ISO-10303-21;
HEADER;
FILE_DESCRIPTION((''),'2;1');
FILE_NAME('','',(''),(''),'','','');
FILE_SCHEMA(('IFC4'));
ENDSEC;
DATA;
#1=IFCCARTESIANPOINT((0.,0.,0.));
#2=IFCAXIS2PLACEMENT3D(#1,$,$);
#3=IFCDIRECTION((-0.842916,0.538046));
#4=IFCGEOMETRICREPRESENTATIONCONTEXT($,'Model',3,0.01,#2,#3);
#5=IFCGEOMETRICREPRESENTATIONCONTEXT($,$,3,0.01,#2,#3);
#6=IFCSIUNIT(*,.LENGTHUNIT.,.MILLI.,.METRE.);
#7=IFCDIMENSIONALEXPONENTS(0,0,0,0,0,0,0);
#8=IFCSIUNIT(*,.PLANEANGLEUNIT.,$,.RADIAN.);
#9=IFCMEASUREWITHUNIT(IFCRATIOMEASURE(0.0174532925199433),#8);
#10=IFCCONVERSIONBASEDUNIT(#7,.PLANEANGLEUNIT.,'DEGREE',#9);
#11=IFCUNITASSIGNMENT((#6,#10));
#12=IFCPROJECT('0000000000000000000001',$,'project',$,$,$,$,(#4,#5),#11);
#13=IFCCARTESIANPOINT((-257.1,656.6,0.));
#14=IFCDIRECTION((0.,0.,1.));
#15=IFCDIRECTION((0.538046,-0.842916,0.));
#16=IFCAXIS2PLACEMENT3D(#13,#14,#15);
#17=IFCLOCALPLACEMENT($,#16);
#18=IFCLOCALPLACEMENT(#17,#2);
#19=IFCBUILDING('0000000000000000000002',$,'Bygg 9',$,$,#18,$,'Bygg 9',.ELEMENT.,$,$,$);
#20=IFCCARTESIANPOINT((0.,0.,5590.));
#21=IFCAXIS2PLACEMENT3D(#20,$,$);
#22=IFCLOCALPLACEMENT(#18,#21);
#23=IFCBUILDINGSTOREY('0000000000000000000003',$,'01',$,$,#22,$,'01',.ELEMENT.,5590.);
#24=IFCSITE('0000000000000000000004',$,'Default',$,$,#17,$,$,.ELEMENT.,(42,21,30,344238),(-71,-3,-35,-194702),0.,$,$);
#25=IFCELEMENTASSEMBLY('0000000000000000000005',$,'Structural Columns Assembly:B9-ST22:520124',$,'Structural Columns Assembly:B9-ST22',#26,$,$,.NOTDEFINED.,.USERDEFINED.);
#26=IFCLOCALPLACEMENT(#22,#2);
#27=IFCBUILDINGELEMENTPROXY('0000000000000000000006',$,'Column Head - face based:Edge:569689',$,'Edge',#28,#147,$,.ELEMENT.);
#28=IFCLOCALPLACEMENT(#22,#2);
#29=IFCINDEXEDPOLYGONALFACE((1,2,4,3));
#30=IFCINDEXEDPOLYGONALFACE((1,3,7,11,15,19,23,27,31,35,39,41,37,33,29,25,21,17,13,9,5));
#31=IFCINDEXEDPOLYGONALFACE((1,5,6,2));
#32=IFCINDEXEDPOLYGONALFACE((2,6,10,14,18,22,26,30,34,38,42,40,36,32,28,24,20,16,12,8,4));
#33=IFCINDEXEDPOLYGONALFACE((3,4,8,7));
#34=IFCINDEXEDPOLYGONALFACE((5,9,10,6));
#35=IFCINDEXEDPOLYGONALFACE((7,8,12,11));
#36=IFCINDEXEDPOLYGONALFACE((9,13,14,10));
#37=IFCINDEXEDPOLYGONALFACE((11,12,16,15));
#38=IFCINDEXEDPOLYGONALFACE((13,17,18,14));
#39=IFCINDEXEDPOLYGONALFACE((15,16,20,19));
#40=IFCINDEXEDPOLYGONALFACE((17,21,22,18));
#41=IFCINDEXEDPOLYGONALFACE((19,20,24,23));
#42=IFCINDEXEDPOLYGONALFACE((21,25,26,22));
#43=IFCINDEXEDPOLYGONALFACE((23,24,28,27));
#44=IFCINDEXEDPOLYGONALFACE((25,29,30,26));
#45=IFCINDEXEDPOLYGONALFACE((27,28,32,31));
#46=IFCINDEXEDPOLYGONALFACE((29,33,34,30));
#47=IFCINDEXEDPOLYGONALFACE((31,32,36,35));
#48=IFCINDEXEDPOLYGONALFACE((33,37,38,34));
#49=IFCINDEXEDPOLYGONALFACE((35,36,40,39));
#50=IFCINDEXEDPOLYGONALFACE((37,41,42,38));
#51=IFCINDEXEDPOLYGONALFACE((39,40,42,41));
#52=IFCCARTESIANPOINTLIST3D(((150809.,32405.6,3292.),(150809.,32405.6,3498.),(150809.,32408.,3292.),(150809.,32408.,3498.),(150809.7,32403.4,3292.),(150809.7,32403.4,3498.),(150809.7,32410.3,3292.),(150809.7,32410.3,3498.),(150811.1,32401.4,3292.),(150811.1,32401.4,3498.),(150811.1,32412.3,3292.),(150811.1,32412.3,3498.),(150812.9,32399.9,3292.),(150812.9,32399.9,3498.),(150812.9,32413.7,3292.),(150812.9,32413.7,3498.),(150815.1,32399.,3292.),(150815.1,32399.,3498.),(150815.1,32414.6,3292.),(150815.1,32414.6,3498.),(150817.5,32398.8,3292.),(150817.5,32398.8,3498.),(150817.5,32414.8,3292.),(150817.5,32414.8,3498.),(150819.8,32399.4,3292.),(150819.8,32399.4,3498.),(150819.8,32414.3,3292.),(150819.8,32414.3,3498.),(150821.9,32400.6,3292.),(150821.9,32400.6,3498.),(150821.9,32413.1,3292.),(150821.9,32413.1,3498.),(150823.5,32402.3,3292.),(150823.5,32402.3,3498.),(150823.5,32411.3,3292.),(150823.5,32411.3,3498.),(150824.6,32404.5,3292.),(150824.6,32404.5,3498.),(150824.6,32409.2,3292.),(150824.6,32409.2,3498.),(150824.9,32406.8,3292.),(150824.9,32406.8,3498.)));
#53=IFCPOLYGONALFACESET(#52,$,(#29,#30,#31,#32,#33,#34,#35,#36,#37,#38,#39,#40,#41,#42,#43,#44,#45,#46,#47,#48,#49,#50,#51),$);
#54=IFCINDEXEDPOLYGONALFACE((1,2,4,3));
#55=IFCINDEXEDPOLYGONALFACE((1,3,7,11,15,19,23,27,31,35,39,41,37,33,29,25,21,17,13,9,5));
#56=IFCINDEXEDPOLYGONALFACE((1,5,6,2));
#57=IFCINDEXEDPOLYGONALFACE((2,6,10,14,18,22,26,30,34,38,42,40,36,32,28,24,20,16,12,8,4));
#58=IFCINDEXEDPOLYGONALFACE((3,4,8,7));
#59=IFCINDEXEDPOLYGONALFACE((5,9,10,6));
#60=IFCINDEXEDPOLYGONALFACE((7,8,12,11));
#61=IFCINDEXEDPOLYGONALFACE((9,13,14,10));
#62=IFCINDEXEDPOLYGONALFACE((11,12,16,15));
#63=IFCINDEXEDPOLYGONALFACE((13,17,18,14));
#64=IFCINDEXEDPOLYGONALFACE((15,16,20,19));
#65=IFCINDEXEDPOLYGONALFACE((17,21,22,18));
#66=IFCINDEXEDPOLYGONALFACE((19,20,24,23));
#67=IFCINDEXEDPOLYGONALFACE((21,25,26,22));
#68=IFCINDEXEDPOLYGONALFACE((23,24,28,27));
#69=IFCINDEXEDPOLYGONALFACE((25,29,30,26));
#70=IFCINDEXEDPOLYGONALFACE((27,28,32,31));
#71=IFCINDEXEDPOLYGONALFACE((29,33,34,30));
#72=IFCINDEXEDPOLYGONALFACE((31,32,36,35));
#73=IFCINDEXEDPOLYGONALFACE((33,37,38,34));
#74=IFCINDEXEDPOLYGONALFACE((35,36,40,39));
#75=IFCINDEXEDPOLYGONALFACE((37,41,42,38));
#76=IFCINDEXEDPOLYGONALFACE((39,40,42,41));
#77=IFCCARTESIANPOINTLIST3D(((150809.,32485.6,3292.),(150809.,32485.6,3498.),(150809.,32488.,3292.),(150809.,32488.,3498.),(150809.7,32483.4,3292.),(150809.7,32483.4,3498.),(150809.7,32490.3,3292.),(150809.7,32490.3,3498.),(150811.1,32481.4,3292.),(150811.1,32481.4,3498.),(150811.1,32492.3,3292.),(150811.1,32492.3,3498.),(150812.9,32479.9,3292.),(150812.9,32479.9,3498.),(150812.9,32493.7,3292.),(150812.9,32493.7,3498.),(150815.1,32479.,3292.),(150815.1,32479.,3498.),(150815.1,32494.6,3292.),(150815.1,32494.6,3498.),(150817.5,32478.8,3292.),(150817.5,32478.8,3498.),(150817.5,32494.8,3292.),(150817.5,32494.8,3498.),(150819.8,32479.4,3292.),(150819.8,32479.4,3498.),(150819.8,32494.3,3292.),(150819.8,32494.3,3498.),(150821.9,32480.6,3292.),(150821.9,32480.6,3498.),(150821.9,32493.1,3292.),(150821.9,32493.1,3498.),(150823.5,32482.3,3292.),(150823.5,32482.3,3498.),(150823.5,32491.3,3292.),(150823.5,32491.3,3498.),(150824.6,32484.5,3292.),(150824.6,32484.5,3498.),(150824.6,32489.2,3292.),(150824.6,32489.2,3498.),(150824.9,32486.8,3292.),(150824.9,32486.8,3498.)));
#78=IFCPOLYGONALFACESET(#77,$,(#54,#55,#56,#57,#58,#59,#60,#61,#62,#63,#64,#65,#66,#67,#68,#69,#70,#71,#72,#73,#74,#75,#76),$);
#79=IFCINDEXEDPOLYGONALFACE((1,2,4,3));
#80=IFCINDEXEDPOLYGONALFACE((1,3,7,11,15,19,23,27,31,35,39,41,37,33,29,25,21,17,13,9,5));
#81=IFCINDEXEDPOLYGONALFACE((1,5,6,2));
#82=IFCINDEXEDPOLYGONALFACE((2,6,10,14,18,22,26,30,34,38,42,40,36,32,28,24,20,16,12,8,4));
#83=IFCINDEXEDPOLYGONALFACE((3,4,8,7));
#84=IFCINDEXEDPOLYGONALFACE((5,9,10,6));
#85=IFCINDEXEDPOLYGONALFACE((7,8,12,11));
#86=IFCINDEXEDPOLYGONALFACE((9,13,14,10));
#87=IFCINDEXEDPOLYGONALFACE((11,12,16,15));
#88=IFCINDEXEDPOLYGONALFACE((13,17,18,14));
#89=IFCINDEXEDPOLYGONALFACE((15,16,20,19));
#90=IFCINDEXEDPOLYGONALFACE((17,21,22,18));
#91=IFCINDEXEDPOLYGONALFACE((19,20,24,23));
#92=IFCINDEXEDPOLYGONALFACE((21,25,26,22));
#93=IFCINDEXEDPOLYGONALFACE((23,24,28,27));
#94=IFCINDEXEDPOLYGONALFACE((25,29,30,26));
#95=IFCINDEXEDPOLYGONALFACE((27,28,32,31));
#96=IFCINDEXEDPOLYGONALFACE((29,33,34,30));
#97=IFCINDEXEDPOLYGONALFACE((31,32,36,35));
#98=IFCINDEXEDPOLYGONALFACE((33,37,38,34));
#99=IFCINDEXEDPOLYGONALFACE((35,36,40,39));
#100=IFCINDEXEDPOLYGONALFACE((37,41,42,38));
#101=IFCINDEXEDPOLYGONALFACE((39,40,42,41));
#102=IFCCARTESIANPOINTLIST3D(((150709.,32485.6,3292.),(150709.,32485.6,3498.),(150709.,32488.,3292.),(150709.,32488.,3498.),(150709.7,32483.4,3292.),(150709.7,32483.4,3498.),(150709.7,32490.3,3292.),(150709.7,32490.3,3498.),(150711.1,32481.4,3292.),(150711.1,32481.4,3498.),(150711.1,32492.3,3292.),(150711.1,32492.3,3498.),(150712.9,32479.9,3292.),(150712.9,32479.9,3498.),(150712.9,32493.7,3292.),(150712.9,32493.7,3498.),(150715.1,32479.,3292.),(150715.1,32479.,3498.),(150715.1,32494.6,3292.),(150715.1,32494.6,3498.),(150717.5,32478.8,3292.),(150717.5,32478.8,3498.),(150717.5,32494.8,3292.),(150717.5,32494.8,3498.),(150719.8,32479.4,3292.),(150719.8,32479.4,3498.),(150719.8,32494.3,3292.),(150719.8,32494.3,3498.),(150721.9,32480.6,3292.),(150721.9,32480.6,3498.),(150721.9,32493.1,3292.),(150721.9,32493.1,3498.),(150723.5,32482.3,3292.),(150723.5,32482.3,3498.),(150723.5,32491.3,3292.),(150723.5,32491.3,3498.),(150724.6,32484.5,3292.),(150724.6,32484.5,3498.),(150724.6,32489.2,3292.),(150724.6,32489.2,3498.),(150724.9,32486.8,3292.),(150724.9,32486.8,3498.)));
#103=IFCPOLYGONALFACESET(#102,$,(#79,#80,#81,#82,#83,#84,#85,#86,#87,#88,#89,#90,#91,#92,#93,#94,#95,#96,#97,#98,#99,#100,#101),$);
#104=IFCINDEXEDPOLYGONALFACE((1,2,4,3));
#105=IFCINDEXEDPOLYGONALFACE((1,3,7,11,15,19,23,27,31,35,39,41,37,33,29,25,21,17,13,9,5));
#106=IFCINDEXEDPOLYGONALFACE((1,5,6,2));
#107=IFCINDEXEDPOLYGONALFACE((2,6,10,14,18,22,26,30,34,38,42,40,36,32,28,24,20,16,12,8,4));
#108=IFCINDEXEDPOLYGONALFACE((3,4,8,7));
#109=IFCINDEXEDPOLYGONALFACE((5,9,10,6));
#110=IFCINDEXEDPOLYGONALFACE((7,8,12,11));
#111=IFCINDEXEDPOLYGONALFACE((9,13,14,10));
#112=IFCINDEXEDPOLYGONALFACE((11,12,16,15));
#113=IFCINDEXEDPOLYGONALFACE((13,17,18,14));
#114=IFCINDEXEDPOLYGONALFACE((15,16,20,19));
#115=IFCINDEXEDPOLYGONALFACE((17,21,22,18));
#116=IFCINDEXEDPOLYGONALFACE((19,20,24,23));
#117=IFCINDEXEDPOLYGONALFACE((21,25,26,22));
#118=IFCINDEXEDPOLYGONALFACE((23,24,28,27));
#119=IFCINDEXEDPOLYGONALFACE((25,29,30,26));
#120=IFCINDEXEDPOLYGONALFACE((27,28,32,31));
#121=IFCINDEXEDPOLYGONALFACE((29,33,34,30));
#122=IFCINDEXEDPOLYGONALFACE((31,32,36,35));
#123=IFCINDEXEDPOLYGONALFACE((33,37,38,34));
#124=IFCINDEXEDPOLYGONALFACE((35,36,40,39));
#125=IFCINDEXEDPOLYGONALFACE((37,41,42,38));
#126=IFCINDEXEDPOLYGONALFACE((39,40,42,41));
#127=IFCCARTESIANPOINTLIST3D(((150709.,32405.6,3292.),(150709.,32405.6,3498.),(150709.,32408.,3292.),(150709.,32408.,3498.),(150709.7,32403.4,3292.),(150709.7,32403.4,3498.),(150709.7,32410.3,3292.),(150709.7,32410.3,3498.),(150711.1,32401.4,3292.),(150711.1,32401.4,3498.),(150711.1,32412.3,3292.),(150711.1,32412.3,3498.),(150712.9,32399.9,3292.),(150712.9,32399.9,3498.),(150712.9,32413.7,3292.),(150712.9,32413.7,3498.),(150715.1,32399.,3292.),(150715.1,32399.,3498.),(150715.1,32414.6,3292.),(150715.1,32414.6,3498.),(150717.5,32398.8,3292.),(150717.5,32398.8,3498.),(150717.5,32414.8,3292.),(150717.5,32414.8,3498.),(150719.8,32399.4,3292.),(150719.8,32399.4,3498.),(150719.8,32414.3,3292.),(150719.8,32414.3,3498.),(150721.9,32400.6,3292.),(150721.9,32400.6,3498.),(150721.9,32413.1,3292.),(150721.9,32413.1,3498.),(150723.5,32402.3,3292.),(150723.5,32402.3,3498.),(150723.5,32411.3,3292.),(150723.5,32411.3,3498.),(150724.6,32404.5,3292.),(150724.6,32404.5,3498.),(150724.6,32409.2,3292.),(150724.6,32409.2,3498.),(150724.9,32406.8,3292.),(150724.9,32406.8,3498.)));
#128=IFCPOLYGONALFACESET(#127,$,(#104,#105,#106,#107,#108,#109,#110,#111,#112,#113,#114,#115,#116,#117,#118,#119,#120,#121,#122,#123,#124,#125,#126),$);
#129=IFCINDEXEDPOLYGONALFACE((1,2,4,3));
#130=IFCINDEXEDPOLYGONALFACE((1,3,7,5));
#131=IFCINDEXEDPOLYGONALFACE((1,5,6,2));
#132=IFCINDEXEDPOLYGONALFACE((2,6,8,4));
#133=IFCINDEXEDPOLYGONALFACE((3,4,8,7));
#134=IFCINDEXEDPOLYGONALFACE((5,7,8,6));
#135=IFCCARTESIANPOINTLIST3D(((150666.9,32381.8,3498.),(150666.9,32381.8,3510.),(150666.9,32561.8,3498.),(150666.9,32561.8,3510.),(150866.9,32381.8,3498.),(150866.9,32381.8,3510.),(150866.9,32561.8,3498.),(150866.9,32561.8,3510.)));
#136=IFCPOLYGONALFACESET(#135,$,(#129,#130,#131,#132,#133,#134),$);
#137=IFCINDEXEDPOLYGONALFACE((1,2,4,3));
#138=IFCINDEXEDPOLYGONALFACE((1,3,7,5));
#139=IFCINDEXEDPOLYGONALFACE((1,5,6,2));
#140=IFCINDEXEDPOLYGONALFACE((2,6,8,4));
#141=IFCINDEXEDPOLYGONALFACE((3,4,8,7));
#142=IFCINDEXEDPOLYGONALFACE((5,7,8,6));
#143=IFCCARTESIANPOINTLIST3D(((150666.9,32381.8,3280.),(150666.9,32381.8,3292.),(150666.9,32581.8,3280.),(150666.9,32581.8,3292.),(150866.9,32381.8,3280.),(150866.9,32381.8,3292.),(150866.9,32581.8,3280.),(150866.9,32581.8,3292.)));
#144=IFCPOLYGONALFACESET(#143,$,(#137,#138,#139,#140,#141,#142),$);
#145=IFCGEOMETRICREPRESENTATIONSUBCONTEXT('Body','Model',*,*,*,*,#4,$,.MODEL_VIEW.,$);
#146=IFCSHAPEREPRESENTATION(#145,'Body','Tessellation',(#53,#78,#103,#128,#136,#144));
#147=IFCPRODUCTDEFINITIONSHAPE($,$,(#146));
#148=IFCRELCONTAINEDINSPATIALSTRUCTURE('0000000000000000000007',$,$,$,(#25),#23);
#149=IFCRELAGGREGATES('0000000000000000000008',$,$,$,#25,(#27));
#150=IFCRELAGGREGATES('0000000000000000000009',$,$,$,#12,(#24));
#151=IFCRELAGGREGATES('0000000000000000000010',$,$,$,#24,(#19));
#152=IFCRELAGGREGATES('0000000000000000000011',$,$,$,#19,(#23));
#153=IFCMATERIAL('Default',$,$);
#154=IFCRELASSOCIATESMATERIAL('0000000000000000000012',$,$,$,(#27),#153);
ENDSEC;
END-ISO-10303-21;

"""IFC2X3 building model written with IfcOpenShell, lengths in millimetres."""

from ifc_helpers import new_model, entity, si_unit, converted_unit, direction, frame, frame_2d, origin, origin_2d_with_axis, place, context, subcontext, project, spatial, rectangle, circle, extrude, source, transform, mapped, material, element, aggregate, save


model = new_model("IFC2X3")

# Units and contexts
model_context = context("Model", 3, precision=0.01, world=origin(), true_north=direction((-0.842916, 0.538046)))
context_of_model = context(None, 3, precision=0.01, world=origin(), true_north=direction((-0.842916, 0.538046)))
body_context = subcontext(model_context, "Body", "Model", "MODEL_VIEW")
ifc_project = project(units=[si_unit("LENGTHUNIT", "METRE", prefix="MILLI"), converted_unit("PLANEANGLEUNIT", "DEGREE", entity("IfcRatioMeasure", 0.0174532925199433), si_unit("PLANEANGLEUNIT", "RADIAN"), dimensions=[0, 0, 0, 0, 0, 0, 0])], contexts=[model_context, context_of_model])

# Site, building, storey
site_placement = place(None, frame((-257.1, 656.6, 0.0), z_axis=(0.0, 0.0, 1.0), x_axis=(0.538046, -0.842916, 0.0)))
site = spatial("IfcSite", under=ifc_project, at=site_placement, Name="Default", CompositionType="ELEMENT", RefLatitude=(42, 21, 30, 344238), RefLongitude=(-71, -3, -35, -194702), RefElevation=0.0)
building_placement = place(site_placement, origin())
building = spatial("IfcBuilding", under=site, at=building_placement, Name="Bygg 9", LongName="Bygg 9", CompositionType="ELEMENT")
storey_placement = place(building_placement, frame((0.0, 0.0, 5590.0)))
storey = spatial("IfcBuildingStorey", under=building, at=storey_placement, Name="01", LongName="01", CompositionType="ELEMENT", Elevation=5590.0)

# Element assembly, building element proxy
ifc_material_1 = material(Name="Default")
shared_shape_1 = source(origin(), body_context, "Body", "SweptSolid", [
    extrude(circle(Radius=8.0, at=frame_2d((0.0, 0.0), x_axis=(1.0, 0.0))), frame((50.0, -135.0, 12.0)), (0.0, 0.0, 1.0), 206.0),
    extrude(circle(Radius=8.0, at=frame_2d((0.0, 0.0), x_axis=(1.0, 0.0))), frame((50.0, -55.0, 12.0)), (0.0, 0.0, 1.0), 206.0),
    extrude(circle(Radius=8.0, at=frame_2d((0.0, 0.0), x_axis=(1.0, 0.0))), frame((-50.0, -55.0, 12.0)), (0.0, 0.0, 1.0), 206.0),
    extrude(circle(Radius=8.0, at=frame_2d((0.0, 0.0), x_axis=(1.0, 0.0))), frame((-50.0, -135.0, 12.0)), (0.0, 0.0, 1.0), 206.0),
    extrude(rectangle(XDim=200.0, YDim=180.0, at=origin_2d_with_axis()), frame((0.0, -70.0, 218.0), z_axis=(0.0, 0.0, 1.0), x_axis=(-1.0, 0.0, 0.0)), (0.0, 0.0, 1.0), 12.0),
    extrude(rectangle(XDim=200.0, YDim=200.0, at=origin_2d_with_axis()), frame((0.0, -60.0, 0.0), z_axis=(0.0, 0.0, 1.0), x_axis=(0.0, 1.0, 0.0)), (0.0, 0.0, 1.0), 12.0),
])
assembly_1_placement = place(storey_placement, origin())
assembly_1 = element("IfcElementAssembly", 1, at=assembly_1_placement, inside=storey, Name="Structural Columns Assembly:B9-ST22:520124", ObjectType="Structural Columns Assembly:B9-ST22", AssemblyPlace="NOTDEFINED", PredefinedType="USERDEFINED")
proxy_1_placement = place(assembly_1_placement, frame((150766.9, 32541.8, 3280.0)))
proxy_1 = element("IfcBuildingElementProxy", 2, at=proxy_1_placement, material=ifc_material_1, Name="Column Head - face based:Edge:569689", ObjectType="Edge", CompositionType="ELEMENT", context=body_context, shape_type="MappedRepresentation", body=[
    mapped(shared_shape_1, transform((0.0, 0.0, 0.0), scale=1.0)),
])
aggregate(assembly_1, [proxy_1])

save(model, "model.ifc")
